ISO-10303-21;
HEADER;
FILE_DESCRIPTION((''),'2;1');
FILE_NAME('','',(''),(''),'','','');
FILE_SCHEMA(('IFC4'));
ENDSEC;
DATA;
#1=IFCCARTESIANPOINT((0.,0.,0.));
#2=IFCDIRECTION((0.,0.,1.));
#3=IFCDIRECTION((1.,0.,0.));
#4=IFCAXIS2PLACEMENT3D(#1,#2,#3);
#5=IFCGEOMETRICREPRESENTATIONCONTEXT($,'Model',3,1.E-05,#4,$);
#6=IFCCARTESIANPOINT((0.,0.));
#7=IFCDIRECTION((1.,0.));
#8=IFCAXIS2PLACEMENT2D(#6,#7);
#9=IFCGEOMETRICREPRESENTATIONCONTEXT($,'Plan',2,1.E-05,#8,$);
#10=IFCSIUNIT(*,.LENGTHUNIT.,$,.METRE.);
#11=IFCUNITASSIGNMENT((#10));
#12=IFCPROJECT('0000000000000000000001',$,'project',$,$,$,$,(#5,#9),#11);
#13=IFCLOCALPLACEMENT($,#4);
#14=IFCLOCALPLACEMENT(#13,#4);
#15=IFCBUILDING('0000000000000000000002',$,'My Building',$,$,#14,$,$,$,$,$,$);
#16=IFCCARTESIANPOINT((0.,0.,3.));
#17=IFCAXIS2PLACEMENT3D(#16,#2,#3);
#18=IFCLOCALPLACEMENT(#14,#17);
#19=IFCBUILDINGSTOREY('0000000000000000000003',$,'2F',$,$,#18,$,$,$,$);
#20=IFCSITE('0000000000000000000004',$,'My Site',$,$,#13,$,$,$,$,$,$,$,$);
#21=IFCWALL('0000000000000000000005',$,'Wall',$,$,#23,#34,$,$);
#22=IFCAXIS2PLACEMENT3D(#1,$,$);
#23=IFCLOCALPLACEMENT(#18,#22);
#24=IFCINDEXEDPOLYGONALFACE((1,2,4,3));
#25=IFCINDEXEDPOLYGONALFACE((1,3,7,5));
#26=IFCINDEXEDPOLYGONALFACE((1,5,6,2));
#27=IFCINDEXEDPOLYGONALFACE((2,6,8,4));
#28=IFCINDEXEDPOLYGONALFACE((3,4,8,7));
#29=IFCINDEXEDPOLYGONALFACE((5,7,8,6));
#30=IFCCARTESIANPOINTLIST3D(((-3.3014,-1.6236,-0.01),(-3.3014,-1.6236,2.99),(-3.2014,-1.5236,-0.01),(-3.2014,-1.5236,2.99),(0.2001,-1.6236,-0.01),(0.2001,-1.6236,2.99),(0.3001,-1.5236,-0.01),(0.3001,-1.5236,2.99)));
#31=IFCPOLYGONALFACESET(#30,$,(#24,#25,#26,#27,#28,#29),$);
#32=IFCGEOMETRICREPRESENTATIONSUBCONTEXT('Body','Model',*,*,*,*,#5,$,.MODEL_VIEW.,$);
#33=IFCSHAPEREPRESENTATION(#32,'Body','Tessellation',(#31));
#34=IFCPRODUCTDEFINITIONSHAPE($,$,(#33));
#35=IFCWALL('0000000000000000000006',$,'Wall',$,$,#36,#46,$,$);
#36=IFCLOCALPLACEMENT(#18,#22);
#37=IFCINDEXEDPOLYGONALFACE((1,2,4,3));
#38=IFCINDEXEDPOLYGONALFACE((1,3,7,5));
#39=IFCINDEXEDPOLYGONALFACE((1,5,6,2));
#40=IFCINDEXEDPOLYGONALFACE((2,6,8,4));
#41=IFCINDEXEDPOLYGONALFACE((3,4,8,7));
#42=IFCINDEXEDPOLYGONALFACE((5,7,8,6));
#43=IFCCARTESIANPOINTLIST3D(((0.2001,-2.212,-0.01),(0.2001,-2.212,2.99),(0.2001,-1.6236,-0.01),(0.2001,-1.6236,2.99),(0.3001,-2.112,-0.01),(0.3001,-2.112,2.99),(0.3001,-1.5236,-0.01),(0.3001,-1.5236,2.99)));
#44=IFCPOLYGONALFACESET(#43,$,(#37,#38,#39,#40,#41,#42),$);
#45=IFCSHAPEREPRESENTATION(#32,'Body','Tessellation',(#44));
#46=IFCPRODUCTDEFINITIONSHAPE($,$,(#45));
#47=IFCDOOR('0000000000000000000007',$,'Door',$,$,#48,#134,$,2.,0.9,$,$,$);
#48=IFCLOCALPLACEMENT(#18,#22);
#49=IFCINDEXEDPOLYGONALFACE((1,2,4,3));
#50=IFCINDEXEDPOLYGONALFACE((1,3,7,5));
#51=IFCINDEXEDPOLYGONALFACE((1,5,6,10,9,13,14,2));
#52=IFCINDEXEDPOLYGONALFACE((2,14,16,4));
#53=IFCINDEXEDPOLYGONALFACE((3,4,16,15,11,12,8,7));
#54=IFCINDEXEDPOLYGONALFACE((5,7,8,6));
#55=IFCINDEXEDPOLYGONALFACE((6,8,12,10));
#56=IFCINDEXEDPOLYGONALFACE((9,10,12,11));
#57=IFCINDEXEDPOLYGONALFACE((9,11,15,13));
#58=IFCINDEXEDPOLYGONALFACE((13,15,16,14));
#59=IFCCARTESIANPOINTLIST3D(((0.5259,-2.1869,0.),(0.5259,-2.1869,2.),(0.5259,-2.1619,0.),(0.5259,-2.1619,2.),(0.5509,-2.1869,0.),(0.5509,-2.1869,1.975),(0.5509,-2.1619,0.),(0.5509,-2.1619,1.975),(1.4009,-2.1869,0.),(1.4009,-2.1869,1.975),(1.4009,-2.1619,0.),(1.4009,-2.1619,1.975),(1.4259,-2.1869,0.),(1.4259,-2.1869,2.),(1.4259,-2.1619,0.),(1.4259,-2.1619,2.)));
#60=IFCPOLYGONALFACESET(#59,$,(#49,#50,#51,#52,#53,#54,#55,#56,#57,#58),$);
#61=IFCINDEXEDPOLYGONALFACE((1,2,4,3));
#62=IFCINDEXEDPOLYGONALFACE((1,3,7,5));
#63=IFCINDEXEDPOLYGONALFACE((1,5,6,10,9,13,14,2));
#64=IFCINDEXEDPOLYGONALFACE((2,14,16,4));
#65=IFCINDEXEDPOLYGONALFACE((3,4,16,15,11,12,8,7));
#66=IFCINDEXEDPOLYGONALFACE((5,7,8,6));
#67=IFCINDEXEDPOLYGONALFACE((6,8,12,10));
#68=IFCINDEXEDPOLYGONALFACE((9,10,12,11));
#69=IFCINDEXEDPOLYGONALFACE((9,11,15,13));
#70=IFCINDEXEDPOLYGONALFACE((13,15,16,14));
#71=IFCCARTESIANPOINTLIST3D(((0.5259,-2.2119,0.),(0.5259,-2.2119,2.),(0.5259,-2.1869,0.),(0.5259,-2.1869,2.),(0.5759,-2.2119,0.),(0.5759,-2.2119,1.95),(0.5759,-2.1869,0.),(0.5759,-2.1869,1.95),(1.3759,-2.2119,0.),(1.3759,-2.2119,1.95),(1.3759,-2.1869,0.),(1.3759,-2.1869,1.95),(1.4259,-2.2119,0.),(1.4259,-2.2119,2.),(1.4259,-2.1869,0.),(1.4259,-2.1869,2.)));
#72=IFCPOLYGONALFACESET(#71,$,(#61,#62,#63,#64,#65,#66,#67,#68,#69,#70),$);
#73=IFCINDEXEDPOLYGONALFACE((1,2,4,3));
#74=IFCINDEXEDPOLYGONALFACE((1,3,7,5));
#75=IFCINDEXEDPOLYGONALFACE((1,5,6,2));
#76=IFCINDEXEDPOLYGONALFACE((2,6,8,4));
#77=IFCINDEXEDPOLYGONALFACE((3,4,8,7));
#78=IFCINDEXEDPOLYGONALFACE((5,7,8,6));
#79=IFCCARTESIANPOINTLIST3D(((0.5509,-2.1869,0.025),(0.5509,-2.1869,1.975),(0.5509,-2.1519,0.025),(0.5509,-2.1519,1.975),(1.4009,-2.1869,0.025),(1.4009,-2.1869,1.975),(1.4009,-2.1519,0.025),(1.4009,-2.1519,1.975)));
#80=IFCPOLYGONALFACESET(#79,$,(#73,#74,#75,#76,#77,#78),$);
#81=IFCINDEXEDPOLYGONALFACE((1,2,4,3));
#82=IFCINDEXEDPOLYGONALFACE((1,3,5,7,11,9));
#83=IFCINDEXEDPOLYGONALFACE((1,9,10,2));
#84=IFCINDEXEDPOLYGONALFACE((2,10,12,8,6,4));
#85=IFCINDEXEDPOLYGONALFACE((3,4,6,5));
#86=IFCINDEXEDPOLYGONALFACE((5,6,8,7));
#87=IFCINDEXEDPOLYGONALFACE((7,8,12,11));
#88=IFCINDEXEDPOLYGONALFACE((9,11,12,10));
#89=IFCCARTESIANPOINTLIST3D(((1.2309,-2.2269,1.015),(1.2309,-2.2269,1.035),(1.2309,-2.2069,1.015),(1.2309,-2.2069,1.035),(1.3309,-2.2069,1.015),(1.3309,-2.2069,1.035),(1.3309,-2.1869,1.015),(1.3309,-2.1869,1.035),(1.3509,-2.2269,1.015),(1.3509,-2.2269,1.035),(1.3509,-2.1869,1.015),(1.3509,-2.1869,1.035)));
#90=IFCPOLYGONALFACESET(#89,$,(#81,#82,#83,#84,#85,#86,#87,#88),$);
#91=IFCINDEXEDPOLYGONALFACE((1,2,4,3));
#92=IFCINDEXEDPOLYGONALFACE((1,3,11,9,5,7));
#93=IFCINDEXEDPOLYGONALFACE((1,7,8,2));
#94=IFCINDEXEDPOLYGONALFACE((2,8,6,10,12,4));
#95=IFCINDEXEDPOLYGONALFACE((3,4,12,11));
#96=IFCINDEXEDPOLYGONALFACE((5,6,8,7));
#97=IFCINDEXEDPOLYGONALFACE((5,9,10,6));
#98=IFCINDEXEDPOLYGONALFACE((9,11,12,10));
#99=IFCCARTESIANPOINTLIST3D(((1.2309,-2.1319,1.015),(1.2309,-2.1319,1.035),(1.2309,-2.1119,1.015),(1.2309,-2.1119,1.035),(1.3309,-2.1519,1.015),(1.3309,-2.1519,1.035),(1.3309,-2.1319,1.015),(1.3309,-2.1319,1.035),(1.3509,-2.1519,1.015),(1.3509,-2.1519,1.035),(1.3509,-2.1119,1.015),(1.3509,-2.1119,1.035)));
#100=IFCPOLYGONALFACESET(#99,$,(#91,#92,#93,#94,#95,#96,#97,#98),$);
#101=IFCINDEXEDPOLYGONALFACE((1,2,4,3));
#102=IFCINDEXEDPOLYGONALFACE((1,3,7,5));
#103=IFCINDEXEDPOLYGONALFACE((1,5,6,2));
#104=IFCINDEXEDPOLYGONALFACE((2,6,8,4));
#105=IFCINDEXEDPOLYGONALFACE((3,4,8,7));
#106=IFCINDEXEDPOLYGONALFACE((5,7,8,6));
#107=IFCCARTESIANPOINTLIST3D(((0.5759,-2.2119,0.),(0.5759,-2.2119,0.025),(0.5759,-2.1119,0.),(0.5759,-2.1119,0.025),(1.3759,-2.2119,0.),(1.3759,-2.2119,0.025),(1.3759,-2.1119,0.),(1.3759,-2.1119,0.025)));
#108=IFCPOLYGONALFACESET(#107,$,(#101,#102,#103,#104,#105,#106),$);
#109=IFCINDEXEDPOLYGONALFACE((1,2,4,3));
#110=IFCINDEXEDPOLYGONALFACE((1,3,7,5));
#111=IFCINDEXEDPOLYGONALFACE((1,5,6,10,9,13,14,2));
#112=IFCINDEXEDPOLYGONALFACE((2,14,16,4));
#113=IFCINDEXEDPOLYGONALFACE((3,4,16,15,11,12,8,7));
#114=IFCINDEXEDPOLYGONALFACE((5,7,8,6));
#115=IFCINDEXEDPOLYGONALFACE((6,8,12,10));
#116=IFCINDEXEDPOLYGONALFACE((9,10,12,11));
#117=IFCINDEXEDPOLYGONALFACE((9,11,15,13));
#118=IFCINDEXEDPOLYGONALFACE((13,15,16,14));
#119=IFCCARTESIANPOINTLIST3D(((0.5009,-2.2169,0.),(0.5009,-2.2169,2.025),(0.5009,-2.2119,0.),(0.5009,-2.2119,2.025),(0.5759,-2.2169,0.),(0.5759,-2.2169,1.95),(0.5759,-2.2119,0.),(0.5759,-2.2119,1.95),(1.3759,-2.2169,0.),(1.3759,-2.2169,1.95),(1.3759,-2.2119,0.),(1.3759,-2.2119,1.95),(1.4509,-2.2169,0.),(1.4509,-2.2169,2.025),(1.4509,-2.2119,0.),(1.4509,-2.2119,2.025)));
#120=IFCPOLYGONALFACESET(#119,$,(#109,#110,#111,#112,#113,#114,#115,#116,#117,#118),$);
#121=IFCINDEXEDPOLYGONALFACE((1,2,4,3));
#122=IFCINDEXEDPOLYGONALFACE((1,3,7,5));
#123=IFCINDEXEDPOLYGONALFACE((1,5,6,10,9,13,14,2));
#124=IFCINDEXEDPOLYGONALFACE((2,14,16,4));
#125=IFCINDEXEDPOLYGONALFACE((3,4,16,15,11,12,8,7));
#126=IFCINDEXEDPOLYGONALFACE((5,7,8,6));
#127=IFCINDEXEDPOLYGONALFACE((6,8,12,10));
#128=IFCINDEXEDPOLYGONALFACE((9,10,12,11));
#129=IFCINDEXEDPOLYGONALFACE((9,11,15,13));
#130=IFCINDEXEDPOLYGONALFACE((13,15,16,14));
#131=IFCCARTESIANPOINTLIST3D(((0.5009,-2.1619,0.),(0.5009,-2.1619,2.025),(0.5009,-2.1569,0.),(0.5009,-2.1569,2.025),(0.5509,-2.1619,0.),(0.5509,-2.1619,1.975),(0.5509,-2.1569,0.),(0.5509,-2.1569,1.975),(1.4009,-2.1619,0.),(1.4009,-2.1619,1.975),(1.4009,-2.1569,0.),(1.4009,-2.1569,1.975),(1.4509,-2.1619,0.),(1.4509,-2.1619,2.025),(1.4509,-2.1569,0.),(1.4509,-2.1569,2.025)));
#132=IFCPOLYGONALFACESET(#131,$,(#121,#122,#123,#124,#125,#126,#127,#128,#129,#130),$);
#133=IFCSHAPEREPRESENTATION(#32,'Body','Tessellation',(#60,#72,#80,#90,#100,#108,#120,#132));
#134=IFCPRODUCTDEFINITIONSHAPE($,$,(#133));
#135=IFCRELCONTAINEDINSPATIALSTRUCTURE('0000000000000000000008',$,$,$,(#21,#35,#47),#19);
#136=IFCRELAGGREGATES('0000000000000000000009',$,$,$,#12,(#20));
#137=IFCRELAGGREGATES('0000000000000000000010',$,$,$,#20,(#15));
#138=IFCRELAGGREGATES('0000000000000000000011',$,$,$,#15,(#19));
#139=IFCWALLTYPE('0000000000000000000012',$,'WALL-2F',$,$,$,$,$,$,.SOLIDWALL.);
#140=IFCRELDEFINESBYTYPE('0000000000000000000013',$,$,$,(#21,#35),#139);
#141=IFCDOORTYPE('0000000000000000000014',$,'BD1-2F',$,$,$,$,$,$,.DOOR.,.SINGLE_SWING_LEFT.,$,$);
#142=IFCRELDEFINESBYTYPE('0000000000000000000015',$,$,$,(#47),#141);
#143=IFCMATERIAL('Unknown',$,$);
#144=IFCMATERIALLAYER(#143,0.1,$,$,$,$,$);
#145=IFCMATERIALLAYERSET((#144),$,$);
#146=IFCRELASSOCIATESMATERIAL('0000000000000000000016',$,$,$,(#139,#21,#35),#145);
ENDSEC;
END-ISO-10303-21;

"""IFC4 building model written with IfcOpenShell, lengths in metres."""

from ifc_helpers import new_model, entity, si_unit, frame, origin_with_axes, origin_2d_with_axis, place, context, subcontext, project, spatial, line, indexed_curve, outline, extrude, shape, source, transform, mapped, material, layer, layer_set, layer_usage, type_object, type_shapes, element, save


model = new_model("IFC4")

# Units and contexts
model_context = context("Model", 3, precision=1e-05, world=origin_with_axes())
plan_context = context("Plan", 2, precision=1e-05, world=origin_2d_with_axis())
body_context_1 = subcontext(model_context, "Body", "Model", "MODEL_VIEW")
body_context_2 = subcontext(plan_context, "Body", "Plan", "PLAN_VIEW")
ifc_project = project(units=[si_unit("LENGTHUNIT", "METRE")], contexts=[model_context, plan_context])

# Site, building, storey
site_placement = place(None, origin_with_axes())
site = spatial("IfcSite", under=ifc_project, at=site_placement, Name="My Site")
building_placement = place(site_placement, origin_with_axes())
building = spatial("IfcBuilding", under=site, at=building_placement, Name="My Building")
storey_placement = place(building_placement, frame((0.0, 0.0, 3.0), z_axis=(0.0, 0.0, 1.0), x_axis=(1.0, 0.0, 0.0)))
storey = spatial("IfcBuildingStorey", under=building, at=storey_placement, Name="2F")

# Shared definitions
ifc_material_1 = material(Name="Unknown")

# Shared definitions
ifc_layer_1 = layer(ifc_material_1, 0.1)
ifc_layer_set_1 = layer_set([ifc_layer_1])
wall_type_1 = type_object("IfcWallType", Name="WALL-2F", PredefinedType="SOLIDWALL", material=ifc_layer_set_1)

# Walls
ifc_layer_usage_1 = layer_usage(ifc_layer_set_1, "AXIS2", "POSITIVE", 0.0)
wall_1_placement = place(storey_placement, frame((-3.3014, -1.6236, -0.01), z_axis=(0.0, 0.0, 1.0), x_axis=(1.0, 0.0, 0.0)))
element("IfcWall", 1, at=wall_1_placement, inside=storey, type_object=wall_type_1, material=ifc_layer_usage_1, Name="Wall", context=body_context_1, shape_type="SweptSolid", body=[
    extrude(outline(indexed_curve([(0.0, 0.0), (0.1, 0.1), (3.6015, 0.1), (3.5015, 0.0)], segments=[line(1, 2, 3, 4, 1)])), origin_with_axes(), (0.0, 0.0, 1.0), 3.0),
])
ifc_layer_usage_2 = layer_usage(ifc_layer_set_1, "AXIS2", "POSITIVE", 0.0)
wall_2_placement = place(storey_placement, frame((0.2001, -1.6236, -0.01), z_axis=(0.0, 0.0, 1.0), x_axis=(0.0, -1.0, 0.0)))
element("IfcWall", 2, at=wall_2_placement, inside=storey, type_object=wall_type_1, material=ifc_layer_usage_2, Name="Wall", context=body_context_1, shape_type="SweptSolid", body=[
    extrude(outline(indexed_curve([(0.0, 0.0), (-0.1, 0.1), (0.4884, 0.1), (0.5884, 0.0)], segments=[line(1, 2, 3, 4, 1)])), origin_with_axes(), (0.0, 0.0, 1.0), 3.0),
])

# Door
door_type_1 = type_object("IfcDoorType", Name="BD1-2F", OperationType="SINGLE_SWING_LEFT", PredefinedType="DOOR")
shared_shape_1 = source(origin_with_axes(), body_context_1, "Body", "SweptSolid", [
    extrude(outline(indexed_curve([(0.0, 0.0), (0.0, 2.0), (0.9, 2.0), (0.9, 0.0), (0.875, 0.0), (0.875, 1.975), (0.025, 1.975), (0.025, 0.0)], segments=[line(1, 2, 3, 4, 5, 6, 7, 8, 1)])), frame((0.0, 0.025, 0.0), z_axis=(0.0, -1.0, 0.0), x_axis=(1.0, 0.0, 0.0)), (0.0, 0.0, -1.0), 0.025),
    extrude(outline(indexed_curve([(0.0, 0.0), (0.0, 2.0), (0.9, 2.0), (0.9, 0.0), (0.85, 0.0), (0.85, 1.95), (0.05, 1.95), (0.05, 0.0)], segments=[line(1, 2, 3, 4, 5, 6, 7, 8, 1)])), frame((0.0, 0.0, 0.0), z_axis=(0.0, -1.0, 0.0), x_axis=(1.0, 0.0, 0.0)), (0.0, 0.0, -1.0), 0.025),
    extrude(outline(indexed_curve([(0.0, 0.0), (0.85, 0.0), (0.85, 0.035), (0.0, 0.035)], segments=[line(1, 2, 3, 4, 1)])), frame((0.025, 0.025, 0.025), z_axis=(0.0, 0.0, 1.0), x_axis=(1.0, 0.0, 0.0)), (0.0, 0.0, 1.0), 1.95),
    extrude(outline(indexed_curve([(0.0, 0.0), (0.0, -0.04), (-0.12, -0.04), (-0.12, -0.02), (-0.02, -0.02), (-0.02, 0.0)], segments=[line(1, 2, 3, 4, 5, 6, 1)])), frame((0.825, 0.025, 1.015), z_axis=(0.0, 0.0, 1.0), x_axis=(1.0, 0.0, 0.0)), (0.0, 0.0, 1.0), 0.02),
    extrude(outline(indexed_curve([(0.0, 0.0), (0.0, 0.04), (-0.12, 0.04), (-0.12, 0.02), (-0.02, 0.02), (-0.02, 0.0)], segments=[line(1, 2, 3, 4, 5, 6, 1)])), frame((0.825, 0.06, 1.015), z_axis=(0.0, 0.0, 1.0), x_axis=(1.0, 0.0, 0.0)), (0.0, 0.0, 1.0), 0.02),
    extrude(outline(indexed_curve([(0.0, 0.0), (0.8, 0.0), (0.8, 0.1), (0.0, 0.1)], segments=[line(1, 2, 3, 4, 1)])), frame((0.05, 0.0, 0.0), z_axis=(0.0, 0.0, 1.0), x_axis=(1.0, 0.0, 0.0)), (0.0, 0.0, 1.0), 0.025),
    extrude(outline(indexed_curve([(0.0, 0.0), (0.0, 2.025), (0.95, 2.025), (0.95, 0.0), (0.875, 0.0), (0.875, 1.95), (0.075, 1.95), (0.075, 0.0)], segments=[line(1, 2, 3, 4, 5, 6, 7, 8, 1)])), frame((-0.025, -0.005, 0.0), z_axis=(0.0, -1.0, 0.0), x_axis=(1.0, 0.0, 0.0)), (0.0, 0.0, -1.0), 0.005),
    extrude(outline(indexed_curve([(0.0, 0.0), (0.0, 2.025), (0.95, 2.025), (0.95, 0.0), (0.9, 0.0), (0.9, 1.975), (0.05, 1.975), (0.05, 0.0)], segments=[line(1, 2, 3, 4, 5, 6, 7, 8, 1)])), frame((-0.025, 0.05, 0.0), z_axis=(0.0, -1.0, 0.0), x_axis=(1.0, 0.0, 0.0)), (0.0, 0.0, -1.0), 0.005),
])
shared_shape_2 = source(origin_with_axes(), body_context_2, "Body", "Curve2D", [
    entity("IfcIndexedPolyCurve", entity("IfcCartesianPointList2D", [[0.0, 0.0], [0.0, 0.05], [0.025, 0.05], [0.025, 0.025], [0.05, 0.025], [0.05, 0.0]]), [entity("IfcLineIndex", [1, 2, 3, 4, 5, 6, 1])]),
    entity("IfcIndexedPolyCurve", entity("IfcCartesianPointList2D", [[0.9, 0.0], [0.9, 0.05], [0.875, 0.05], [0.875, 0.025], [0.85, 0.025], [0.85, 0.0]]), [entity("IfcLineIndex", [1, 2, 3, 4, 5, 6, 1])]),
    entity("IfcTrimmedCurve", entity("IfcEllipse", entity("IfcAxis2Placement2D", entity("IfcCartesianPoint", [0.06, 0.05]), entity("IfcDirection", [1.0, 0.0])), 0.815, 0.85), [entity("IfcCartesianPoint", [0.875, 0.05])], [entity("IfcCartesianPoint", [0.06, 0.9])], True, "CARTESIAN"),
    entity("IfcIndexedPolyCurve", entity("IfcCartesianPointList2D", [[0.025, 0.05], [0.06, 0.05], [0.06, 0.9], [0.025, 0.9]]), [entity("IfcLineIndex", [1, 2, 3, 4, 1])]),
])
type_shapes(door_type_1, [shared_shape_1, shared_shape_2])
door_1_placement = place(storey_placement, frame((0.5259, -2.2119, 0.0), z_axis=(0.0, 0.0, 1.0), x_axis=(1.0, 0.0, 0.0)))
element("IfcDoor", 3, at=door_1_placement, inside=storey, type_object=door_type_1, Name="Door", OverallHeight=2.0, OverallWidth=0.9, shapes=[
    shape(body_context_1, "Body", "MappedRepresentation", [mapped(shared_shape_1, transform((0.0, 0.0, 0.0), x_axis=(1.0, 0.0, 0.0), y_axis=(0.0, 1.0, 0.0), z_axis=(0.0, 0.0, 1.0), scale=1.0))]),
    shape(body_context_2, "Body", "MappedRepresentation", [mapped(shared_shape_2, transform((0.0, 0.0, 0.0), x_axis=(1.0, 0.0, 0.0), y_axis=(0.0, 1.0, 0.0), z_axis=(0.0, 0.0, 1.0), scale=1.0))]),
])

save(model, "model.ifc")
